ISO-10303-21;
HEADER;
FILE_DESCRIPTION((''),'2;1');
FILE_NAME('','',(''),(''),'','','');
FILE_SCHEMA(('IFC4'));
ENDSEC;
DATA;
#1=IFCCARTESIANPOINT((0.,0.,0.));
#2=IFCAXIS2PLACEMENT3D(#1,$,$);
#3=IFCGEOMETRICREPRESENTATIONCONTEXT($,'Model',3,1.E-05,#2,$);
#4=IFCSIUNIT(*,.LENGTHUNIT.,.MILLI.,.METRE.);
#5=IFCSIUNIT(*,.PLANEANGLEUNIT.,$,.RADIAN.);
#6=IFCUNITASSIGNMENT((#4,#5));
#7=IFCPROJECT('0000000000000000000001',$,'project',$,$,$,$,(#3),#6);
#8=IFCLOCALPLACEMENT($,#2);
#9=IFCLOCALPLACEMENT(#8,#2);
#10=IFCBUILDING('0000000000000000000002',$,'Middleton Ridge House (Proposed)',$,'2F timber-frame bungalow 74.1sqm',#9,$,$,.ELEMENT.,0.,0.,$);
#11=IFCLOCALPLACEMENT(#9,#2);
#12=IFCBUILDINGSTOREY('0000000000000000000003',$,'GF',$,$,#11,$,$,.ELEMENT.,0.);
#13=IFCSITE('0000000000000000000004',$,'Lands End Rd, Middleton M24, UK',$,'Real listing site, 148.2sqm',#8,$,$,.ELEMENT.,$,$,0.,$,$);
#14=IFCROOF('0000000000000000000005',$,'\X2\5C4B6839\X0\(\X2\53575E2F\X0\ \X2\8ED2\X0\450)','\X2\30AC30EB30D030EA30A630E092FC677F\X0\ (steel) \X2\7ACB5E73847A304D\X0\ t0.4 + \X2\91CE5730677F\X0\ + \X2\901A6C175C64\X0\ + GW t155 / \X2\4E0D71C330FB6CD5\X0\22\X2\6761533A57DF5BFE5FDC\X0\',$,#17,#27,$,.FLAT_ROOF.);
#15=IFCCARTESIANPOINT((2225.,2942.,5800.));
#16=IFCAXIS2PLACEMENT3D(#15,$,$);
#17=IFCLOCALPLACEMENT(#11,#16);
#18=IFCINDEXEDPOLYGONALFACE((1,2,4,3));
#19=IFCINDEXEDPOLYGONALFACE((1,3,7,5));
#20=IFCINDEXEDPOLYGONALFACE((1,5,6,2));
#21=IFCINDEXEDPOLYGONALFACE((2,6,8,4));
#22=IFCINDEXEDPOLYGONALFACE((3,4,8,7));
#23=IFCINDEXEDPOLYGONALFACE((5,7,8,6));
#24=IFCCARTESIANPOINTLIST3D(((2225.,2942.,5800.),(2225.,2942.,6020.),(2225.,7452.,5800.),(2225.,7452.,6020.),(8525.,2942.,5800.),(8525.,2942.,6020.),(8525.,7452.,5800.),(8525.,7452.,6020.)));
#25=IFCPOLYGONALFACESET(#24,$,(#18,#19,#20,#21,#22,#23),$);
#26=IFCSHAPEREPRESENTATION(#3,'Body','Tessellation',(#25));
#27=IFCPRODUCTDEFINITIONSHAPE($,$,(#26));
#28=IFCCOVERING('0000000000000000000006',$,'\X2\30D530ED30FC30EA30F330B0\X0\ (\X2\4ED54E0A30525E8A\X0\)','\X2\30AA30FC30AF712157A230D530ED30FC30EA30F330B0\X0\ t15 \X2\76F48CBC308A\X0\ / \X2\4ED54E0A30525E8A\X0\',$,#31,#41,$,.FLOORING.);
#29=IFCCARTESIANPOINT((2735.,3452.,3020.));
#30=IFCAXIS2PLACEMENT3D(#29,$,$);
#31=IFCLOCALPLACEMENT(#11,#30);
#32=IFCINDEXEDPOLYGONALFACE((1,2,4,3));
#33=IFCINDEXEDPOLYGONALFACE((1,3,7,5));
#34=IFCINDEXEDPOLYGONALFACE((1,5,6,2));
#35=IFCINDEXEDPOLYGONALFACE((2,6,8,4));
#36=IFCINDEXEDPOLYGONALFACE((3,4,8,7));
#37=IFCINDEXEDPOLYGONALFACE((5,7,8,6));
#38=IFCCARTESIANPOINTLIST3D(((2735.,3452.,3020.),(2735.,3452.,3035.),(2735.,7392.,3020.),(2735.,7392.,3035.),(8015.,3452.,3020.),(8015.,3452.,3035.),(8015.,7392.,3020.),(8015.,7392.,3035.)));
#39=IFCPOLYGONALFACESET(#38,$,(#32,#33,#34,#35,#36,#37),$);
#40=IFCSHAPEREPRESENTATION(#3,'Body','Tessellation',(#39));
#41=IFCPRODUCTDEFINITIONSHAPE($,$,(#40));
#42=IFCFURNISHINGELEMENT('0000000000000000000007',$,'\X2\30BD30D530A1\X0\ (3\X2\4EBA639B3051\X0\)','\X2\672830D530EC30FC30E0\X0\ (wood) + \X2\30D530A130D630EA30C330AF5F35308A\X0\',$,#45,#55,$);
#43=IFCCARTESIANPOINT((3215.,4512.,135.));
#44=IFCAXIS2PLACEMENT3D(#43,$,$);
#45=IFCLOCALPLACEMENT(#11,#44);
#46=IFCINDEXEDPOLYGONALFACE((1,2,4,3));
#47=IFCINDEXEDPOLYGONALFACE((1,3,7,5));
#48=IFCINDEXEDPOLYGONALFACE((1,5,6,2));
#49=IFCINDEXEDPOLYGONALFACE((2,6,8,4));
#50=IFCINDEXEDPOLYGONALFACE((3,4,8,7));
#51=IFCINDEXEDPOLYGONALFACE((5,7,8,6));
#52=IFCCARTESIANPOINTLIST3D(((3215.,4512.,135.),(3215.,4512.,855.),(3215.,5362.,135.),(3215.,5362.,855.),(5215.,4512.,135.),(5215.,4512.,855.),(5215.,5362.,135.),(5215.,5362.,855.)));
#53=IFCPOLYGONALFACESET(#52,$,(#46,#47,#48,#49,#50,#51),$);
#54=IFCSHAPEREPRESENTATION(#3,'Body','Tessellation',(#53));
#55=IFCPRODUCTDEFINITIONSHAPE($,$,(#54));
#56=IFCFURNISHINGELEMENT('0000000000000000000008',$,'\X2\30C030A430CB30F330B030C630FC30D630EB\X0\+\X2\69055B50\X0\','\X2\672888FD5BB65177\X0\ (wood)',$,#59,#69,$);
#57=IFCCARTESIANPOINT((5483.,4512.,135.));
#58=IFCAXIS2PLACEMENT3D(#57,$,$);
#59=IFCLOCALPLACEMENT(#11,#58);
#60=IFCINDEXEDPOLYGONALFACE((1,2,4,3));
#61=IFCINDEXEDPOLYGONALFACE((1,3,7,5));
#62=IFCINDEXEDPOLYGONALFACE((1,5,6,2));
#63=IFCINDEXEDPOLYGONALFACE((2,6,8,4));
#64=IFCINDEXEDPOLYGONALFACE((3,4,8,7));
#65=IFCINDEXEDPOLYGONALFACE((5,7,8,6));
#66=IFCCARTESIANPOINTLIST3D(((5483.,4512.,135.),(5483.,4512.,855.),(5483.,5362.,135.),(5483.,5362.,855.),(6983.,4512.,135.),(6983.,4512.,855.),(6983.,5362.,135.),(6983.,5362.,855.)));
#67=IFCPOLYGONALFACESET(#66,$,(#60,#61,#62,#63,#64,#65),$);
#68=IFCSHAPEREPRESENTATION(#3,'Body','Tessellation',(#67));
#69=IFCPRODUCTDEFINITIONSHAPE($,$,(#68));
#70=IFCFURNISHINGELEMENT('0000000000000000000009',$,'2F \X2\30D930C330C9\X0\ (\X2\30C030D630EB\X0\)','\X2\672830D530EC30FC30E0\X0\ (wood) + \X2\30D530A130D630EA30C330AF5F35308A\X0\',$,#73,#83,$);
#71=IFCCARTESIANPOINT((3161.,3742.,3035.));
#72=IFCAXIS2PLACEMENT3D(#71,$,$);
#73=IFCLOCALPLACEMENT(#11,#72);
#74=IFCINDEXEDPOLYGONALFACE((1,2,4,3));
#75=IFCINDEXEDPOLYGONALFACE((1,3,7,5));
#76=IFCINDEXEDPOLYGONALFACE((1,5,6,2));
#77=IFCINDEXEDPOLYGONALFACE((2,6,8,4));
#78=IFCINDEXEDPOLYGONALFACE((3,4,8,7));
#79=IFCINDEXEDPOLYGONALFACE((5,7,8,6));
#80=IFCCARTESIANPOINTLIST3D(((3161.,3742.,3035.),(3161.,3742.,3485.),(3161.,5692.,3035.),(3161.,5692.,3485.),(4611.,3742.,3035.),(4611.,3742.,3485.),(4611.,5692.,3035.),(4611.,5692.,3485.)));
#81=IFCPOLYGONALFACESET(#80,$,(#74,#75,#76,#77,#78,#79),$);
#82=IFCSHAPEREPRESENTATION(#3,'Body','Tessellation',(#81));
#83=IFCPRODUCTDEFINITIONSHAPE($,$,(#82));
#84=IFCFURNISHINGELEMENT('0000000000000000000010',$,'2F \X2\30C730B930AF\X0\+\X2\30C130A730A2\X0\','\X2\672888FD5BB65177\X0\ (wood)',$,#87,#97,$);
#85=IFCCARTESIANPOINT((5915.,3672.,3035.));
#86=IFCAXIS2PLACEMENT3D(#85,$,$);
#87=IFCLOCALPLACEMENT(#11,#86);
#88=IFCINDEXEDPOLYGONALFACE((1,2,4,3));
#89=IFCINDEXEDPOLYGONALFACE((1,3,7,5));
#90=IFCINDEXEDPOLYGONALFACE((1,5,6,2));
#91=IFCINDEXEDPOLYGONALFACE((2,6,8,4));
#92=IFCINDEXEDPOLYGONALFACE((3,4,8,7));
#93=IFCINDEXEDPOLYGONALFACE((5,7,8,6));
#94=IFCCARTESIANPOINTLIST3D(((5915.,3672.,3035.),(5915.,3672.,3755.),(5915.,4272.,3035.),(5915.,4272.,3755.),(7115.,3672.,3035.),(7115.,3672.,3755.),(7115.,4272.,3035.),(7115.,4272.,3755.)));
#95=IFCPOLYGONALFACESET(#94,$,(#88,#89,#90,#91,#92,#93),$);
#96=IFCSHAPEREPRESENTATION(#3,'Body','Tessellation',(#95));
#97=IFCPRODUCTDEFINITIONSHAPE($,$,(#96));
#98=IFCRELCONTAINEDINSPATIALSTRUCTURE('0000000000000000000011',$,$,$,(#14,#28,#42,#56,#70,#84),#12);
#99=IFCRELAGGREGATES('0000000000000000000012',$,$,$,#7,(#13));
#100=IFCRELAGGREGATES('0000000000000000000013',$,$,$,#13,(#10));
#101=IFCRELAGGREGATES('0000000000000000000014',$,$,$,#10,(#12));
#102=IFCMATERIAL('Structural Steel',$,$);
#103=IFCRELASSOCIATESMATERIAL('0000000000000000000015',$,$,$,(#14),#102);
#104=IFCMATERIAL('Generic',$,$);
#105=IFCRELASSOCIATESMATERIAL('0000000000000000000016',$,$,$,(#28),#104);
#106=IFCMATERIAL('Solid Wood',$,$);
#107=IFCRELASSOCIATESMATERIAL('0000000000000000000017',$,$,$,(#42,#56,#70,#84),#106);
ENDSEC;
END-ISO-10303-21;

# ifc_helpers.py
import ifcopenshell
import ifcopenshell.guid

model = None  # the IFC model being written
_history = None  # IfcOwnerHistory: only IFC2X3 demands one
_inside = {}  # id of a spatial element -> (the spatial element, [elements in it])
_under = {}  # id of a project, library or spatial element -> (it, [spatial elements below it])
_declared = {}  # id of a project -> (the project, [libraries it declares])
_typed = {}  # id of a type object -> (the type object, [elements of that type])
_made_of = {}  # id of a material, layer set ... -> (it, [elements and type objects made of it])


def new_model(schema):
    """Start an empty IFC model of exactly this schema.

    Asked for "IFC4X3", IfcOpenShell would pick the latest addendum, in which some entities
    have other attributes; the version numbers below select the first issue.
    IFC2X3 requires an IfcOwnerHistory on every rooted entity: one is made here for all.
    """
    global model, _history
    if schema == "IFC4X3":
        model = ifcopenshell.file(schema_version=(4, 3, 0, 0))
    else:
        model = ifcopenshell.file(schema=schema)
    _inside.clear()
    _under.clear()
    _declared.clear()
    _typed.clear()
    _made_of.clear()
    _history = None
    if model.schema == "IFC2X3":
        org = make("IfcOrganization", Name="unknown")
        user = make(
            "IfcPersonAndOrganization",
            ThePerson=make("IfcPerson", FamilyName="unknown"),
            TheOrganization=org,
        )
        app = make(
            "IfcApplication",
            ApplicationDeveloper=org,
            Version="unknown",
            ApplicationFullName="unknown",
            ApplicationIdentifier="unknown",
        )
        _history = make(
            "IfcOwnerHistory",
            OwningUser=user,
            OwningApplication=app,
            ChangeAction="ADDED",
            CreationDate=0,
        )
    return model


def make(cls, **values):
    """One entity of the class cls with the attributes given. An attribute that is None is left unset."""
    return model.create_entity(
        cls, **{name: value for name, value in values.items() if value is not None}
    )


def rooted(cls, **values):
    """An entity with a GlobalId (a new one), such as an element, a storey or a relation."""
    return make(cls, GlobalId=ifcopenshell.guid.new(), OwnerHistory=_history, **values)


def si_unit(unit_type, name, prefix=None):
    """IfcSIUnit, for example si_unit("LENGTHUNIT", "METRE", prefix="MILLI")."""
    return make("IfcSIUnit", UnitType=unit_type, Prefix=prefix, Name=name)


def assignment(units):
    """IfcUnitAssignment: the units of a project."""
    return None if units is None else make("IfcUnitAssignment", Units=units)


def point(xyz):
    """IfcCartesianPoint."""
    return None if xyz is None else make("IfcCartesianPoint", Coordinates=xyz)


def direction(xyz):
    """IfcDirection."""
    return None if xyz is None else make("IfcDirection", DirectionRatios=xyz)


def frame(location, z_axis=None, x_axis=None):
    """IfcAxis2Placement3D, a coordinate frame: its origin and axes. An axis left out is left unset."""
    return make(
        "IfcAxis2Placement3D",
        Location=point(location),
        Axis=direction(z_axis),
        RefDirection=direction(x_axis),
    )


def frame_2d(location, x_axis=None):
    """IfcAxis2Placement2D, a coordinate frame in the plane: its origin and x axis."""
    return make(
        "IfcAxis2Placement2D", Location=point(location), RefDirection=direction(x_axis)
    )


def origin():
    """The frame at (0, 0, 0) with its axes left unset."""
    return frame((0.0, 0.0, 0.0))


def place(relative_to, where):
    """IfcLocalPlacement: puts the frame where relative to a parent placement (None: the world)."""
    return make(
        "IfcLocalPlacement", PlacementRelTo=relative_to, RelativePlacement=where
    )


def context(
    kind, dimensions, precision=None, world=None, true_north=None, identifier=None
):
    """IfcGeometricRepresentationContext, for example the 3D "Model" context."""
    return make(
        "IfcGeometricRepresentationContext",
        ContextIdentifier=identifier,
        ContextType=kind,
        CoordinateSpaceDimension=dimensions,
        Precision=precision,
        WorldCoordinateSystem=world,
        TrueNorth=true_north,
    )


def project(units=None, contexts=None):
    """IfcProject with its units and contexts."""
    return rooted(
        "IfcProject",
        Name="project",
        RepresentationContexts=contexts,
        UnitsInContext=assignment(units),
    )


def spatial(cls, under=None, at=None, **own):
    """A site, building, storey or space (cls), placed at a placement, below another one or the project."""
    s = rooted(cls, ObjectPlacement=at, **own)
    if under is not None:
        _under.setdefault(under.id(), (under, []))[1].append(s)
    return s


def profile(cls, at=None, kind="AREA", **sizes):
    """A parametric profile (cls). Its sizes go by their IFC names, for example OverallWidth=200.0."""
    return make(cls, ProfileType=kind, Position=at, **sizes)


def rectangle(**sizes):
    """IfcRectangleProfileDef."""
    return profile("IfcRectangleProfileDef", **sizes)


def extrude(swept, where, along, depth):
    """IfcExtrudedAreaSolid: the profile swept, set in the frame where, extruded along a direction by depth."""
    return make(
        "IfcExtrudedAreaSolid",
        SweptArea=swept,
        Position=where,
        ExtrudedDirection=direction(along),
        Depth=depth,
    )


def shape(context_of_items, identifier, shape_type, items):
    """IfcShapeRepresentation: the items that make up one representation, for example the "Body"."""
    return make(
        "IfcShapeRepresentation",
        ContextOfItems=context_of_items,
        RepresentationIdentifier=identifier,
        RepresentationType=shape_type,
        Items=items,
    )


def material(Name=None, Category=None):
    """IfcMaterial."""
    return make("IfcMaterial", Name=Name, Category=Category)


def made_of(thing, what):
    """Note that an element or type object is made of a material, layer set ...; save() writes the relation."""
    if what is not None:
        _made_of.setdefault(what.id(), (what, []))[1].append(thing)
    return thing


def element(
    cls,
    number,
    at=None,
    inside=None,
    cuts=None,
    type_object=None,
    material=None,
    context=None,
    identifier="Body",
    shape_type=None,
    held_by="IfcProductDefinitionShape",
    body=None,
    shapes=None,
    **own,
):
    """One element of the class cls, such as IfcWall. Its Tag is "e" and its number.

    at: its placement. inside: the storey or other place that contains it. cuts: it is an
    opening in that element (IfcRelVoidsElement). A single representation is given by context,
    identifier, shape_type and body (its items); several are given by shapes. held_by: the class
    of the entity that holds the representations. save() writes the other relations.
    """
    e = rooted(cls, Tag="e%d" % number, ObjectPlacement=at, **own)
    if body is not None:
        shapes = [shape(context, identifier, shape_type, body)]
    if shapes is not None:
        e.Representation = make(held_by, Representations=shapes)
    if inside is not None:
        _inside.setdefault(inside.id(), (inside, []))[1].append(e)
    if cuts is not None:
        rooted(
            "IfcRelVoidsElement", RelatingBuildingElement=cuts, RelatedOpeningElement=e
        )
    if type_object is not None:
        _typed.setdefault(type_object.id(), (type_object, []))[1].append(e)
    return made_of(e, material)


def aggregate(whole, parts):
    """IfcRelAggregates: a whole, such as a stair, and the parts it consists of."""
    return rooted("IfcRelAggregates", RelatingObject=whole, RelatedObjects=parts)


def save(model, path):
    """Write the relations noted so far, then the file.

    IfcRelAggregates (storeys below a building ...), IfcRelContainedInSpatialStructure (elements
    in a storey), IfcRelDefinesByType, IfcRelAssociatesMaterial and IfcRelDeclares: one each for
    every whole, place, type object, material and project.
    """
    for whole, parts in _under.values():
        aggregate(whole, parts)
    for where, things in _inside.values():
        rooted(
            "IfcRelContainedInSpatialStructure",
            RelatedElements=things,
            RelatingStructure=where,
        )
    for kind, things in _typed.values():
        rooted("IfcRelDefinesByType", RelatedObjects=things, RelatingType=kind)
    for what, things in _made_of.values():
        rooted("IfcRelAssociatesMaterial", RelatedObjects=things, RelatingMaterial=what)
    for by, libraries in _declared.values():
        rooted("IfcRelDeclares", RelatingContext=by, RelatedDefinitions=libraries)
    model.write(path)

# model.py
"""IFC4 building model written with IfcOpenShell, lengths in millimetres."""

from ifc_helpers import new_model, si_unit, frame, frame_2d, origin, place, context, project, spatial, rectangle, extrude, material, element, save


model = new_model("IFC4")

# Units and contexts
model_context = context("Model", 3, precision=1e-05, world=origin())
ifc_project = project(units=[si_unit("LENGTHUNIT", "METRE", prefix="MILLI"), si_unit("PLANEANGLEUNIT", "RADIAN")], contexts=[model_context])

# Site, building, storey
site_placement = place(None, origin())
site = spatial("IfcSite", under=ifc_project, at=site_placement, Name="Lands End Rd, Middleton M24, UK", ObjectType="Real listing site, 148.2sqm", CompositionType="ELEMENT", RefElevation=0.0)
building_placement = place(site_placement, origin())
building = spatial("IfcBuilding", under=site, at=building_placement, Name="Middleton Ridge House (Proposed)", ObjectType="2F timber-frame bungalow 74.1sqm", CompositionType="ELEMENT", ElevationOfRefHeight=0.0, ElevationOfTerrain=0.0)
storey_placement = place(building_placement, origin())
storey = spatial("IfcBuildingStorey", under=building, at=storey_placement, Name="GF", CompositionType="ELEMENT", Elevation=0.0)

# Shared definitions
ifc_material_1 = material(Name="Solid Wood")

# Roof
ifc_material_2 = material(Name="Structural Steel")
for number, where, name in (
    (1, (2225.0, 2942.0, 5800.0), "屋根(南帯 軒450)"),
):
    element("IfcRoof", number, at=place(storey_placement, frame(where)), inside=storey, material=ifc_material_2, Name=name, Description="ガルバリウム鋼板 (steel) 立平葺き t0.4 + 野地板 + 通気層 + GW t155 / 不燃・法22条区域対応", PredefinedType="FLAT_ROOF", context=model_context, shape_type="SweptSolid", body=[
        extrude(rectangle(XDim=6300.0, YDim=4510.0, at=frame_2d((3150.0, 2255.0))), frame((2225.0, 2942.0, 5800.0)), (0.0, 0.0, 1.0), 220.0),
    ])

# Covering
ifc_material_3 = material(Name="Generic")
covering_placement = place(storey_placement, frame((2735.0, 3452.0, 3020.0)))
element("IfcCovering", 2, at=covering_placement, inside=storey, material=ifc_material_3, Name="フローリング (仕上げ床)", Description="オーク無垢フローリング t15 直貼り / 仕上げ床", PredefinedType="FLOORING", context=model_context, shape_type="SweptSolid", body=[
    extrude(rectangle(XDim=5280.0, YDim=3940.0, at=frame_2d((2640.0, 1970.0))), frame((2735.0, 3452.0, 3020.0)), (0.0, 0.0, 1.0), 15.0),
])

# Furnishing elements
furnishing_1_placement = place(storey_placement, frame((3215.0, 4512.0, 135.0)))
element("IfcFurnishingElement", 3, at=furnishing_1_placement, inside=storey, material=ifc_material_1, Name="ソファ (3人掛け)", Description="木フレーム (wood) + ファブリック張り", context=model_context, shape_type="SweptSolid", body=[
    extrude(rectangle(XDim=2000.0, YDim=850.0, at=frame_2d((1000.0, 425.0))), frame((3215.0, 4512.0, 135.0)), (0.0, 0.0, 1.0), 720.0),
])
furnishing_2_placement = place(storey_placement, frame((5483.0, 4512.0, 135.0)))
element("IfcFurnishingElement", 4, at=furnishing_2_placement, inside=storey, material=ifc_material_1, Name="ダイニングテーブル+椅子", Description="木製家具 (wood)", context=model_context, shape_type="SweptSolid", body=[
    extrude(rectangle(XDim=1500.0, YDim=850.0, at=frame_2d((750.0, 425.0))), frame((5483.0, 4512.0, 135.0)), (0.0, 0.0, 1.0), 720.0),
])
furnishing_3_placement = place(storey_placement, frame((3161.0, 3742.0, 3035.0)))
element("IfcFurnishingElement", 5, at=furnishing_3_placement, inside=storey, material=ifc_material_1, Name="2F ベッド (ダブル)", Description="木フレーム (wood) + ファブリック張り", context=model_context, shape_type="SweptSolid", body=[
    extrude(rectangle(XDim=1450.0, YDim=1950.0, at=frame_2d((725.0, 975.0))), frame((3161.0, 3742.0, 3035.0)), (0.0, 0.0, 1.0), 450.0),
])
furnishing_4_placement = place(storey_placement, frame((5915.0, 3672.0, 3035.0)))
element("IfcFurnishingElement", 6, at=furnishing_4_placement, inside=storey, material=ifc_material_1, Name="2F デスク+チェア", Description="木製家具 (wood)", context=model_context, shape_type="SweptSolid", body=[
    extrude(rectangle(XDim=1200.0, YDim=600.0, at=frame_2d((600.0, 300.0))), frame((5915.0, 3672.0, 3035.0)), (0.0, 0.0, 1.0), 720.0),
])

save(model, "model.ifc")
